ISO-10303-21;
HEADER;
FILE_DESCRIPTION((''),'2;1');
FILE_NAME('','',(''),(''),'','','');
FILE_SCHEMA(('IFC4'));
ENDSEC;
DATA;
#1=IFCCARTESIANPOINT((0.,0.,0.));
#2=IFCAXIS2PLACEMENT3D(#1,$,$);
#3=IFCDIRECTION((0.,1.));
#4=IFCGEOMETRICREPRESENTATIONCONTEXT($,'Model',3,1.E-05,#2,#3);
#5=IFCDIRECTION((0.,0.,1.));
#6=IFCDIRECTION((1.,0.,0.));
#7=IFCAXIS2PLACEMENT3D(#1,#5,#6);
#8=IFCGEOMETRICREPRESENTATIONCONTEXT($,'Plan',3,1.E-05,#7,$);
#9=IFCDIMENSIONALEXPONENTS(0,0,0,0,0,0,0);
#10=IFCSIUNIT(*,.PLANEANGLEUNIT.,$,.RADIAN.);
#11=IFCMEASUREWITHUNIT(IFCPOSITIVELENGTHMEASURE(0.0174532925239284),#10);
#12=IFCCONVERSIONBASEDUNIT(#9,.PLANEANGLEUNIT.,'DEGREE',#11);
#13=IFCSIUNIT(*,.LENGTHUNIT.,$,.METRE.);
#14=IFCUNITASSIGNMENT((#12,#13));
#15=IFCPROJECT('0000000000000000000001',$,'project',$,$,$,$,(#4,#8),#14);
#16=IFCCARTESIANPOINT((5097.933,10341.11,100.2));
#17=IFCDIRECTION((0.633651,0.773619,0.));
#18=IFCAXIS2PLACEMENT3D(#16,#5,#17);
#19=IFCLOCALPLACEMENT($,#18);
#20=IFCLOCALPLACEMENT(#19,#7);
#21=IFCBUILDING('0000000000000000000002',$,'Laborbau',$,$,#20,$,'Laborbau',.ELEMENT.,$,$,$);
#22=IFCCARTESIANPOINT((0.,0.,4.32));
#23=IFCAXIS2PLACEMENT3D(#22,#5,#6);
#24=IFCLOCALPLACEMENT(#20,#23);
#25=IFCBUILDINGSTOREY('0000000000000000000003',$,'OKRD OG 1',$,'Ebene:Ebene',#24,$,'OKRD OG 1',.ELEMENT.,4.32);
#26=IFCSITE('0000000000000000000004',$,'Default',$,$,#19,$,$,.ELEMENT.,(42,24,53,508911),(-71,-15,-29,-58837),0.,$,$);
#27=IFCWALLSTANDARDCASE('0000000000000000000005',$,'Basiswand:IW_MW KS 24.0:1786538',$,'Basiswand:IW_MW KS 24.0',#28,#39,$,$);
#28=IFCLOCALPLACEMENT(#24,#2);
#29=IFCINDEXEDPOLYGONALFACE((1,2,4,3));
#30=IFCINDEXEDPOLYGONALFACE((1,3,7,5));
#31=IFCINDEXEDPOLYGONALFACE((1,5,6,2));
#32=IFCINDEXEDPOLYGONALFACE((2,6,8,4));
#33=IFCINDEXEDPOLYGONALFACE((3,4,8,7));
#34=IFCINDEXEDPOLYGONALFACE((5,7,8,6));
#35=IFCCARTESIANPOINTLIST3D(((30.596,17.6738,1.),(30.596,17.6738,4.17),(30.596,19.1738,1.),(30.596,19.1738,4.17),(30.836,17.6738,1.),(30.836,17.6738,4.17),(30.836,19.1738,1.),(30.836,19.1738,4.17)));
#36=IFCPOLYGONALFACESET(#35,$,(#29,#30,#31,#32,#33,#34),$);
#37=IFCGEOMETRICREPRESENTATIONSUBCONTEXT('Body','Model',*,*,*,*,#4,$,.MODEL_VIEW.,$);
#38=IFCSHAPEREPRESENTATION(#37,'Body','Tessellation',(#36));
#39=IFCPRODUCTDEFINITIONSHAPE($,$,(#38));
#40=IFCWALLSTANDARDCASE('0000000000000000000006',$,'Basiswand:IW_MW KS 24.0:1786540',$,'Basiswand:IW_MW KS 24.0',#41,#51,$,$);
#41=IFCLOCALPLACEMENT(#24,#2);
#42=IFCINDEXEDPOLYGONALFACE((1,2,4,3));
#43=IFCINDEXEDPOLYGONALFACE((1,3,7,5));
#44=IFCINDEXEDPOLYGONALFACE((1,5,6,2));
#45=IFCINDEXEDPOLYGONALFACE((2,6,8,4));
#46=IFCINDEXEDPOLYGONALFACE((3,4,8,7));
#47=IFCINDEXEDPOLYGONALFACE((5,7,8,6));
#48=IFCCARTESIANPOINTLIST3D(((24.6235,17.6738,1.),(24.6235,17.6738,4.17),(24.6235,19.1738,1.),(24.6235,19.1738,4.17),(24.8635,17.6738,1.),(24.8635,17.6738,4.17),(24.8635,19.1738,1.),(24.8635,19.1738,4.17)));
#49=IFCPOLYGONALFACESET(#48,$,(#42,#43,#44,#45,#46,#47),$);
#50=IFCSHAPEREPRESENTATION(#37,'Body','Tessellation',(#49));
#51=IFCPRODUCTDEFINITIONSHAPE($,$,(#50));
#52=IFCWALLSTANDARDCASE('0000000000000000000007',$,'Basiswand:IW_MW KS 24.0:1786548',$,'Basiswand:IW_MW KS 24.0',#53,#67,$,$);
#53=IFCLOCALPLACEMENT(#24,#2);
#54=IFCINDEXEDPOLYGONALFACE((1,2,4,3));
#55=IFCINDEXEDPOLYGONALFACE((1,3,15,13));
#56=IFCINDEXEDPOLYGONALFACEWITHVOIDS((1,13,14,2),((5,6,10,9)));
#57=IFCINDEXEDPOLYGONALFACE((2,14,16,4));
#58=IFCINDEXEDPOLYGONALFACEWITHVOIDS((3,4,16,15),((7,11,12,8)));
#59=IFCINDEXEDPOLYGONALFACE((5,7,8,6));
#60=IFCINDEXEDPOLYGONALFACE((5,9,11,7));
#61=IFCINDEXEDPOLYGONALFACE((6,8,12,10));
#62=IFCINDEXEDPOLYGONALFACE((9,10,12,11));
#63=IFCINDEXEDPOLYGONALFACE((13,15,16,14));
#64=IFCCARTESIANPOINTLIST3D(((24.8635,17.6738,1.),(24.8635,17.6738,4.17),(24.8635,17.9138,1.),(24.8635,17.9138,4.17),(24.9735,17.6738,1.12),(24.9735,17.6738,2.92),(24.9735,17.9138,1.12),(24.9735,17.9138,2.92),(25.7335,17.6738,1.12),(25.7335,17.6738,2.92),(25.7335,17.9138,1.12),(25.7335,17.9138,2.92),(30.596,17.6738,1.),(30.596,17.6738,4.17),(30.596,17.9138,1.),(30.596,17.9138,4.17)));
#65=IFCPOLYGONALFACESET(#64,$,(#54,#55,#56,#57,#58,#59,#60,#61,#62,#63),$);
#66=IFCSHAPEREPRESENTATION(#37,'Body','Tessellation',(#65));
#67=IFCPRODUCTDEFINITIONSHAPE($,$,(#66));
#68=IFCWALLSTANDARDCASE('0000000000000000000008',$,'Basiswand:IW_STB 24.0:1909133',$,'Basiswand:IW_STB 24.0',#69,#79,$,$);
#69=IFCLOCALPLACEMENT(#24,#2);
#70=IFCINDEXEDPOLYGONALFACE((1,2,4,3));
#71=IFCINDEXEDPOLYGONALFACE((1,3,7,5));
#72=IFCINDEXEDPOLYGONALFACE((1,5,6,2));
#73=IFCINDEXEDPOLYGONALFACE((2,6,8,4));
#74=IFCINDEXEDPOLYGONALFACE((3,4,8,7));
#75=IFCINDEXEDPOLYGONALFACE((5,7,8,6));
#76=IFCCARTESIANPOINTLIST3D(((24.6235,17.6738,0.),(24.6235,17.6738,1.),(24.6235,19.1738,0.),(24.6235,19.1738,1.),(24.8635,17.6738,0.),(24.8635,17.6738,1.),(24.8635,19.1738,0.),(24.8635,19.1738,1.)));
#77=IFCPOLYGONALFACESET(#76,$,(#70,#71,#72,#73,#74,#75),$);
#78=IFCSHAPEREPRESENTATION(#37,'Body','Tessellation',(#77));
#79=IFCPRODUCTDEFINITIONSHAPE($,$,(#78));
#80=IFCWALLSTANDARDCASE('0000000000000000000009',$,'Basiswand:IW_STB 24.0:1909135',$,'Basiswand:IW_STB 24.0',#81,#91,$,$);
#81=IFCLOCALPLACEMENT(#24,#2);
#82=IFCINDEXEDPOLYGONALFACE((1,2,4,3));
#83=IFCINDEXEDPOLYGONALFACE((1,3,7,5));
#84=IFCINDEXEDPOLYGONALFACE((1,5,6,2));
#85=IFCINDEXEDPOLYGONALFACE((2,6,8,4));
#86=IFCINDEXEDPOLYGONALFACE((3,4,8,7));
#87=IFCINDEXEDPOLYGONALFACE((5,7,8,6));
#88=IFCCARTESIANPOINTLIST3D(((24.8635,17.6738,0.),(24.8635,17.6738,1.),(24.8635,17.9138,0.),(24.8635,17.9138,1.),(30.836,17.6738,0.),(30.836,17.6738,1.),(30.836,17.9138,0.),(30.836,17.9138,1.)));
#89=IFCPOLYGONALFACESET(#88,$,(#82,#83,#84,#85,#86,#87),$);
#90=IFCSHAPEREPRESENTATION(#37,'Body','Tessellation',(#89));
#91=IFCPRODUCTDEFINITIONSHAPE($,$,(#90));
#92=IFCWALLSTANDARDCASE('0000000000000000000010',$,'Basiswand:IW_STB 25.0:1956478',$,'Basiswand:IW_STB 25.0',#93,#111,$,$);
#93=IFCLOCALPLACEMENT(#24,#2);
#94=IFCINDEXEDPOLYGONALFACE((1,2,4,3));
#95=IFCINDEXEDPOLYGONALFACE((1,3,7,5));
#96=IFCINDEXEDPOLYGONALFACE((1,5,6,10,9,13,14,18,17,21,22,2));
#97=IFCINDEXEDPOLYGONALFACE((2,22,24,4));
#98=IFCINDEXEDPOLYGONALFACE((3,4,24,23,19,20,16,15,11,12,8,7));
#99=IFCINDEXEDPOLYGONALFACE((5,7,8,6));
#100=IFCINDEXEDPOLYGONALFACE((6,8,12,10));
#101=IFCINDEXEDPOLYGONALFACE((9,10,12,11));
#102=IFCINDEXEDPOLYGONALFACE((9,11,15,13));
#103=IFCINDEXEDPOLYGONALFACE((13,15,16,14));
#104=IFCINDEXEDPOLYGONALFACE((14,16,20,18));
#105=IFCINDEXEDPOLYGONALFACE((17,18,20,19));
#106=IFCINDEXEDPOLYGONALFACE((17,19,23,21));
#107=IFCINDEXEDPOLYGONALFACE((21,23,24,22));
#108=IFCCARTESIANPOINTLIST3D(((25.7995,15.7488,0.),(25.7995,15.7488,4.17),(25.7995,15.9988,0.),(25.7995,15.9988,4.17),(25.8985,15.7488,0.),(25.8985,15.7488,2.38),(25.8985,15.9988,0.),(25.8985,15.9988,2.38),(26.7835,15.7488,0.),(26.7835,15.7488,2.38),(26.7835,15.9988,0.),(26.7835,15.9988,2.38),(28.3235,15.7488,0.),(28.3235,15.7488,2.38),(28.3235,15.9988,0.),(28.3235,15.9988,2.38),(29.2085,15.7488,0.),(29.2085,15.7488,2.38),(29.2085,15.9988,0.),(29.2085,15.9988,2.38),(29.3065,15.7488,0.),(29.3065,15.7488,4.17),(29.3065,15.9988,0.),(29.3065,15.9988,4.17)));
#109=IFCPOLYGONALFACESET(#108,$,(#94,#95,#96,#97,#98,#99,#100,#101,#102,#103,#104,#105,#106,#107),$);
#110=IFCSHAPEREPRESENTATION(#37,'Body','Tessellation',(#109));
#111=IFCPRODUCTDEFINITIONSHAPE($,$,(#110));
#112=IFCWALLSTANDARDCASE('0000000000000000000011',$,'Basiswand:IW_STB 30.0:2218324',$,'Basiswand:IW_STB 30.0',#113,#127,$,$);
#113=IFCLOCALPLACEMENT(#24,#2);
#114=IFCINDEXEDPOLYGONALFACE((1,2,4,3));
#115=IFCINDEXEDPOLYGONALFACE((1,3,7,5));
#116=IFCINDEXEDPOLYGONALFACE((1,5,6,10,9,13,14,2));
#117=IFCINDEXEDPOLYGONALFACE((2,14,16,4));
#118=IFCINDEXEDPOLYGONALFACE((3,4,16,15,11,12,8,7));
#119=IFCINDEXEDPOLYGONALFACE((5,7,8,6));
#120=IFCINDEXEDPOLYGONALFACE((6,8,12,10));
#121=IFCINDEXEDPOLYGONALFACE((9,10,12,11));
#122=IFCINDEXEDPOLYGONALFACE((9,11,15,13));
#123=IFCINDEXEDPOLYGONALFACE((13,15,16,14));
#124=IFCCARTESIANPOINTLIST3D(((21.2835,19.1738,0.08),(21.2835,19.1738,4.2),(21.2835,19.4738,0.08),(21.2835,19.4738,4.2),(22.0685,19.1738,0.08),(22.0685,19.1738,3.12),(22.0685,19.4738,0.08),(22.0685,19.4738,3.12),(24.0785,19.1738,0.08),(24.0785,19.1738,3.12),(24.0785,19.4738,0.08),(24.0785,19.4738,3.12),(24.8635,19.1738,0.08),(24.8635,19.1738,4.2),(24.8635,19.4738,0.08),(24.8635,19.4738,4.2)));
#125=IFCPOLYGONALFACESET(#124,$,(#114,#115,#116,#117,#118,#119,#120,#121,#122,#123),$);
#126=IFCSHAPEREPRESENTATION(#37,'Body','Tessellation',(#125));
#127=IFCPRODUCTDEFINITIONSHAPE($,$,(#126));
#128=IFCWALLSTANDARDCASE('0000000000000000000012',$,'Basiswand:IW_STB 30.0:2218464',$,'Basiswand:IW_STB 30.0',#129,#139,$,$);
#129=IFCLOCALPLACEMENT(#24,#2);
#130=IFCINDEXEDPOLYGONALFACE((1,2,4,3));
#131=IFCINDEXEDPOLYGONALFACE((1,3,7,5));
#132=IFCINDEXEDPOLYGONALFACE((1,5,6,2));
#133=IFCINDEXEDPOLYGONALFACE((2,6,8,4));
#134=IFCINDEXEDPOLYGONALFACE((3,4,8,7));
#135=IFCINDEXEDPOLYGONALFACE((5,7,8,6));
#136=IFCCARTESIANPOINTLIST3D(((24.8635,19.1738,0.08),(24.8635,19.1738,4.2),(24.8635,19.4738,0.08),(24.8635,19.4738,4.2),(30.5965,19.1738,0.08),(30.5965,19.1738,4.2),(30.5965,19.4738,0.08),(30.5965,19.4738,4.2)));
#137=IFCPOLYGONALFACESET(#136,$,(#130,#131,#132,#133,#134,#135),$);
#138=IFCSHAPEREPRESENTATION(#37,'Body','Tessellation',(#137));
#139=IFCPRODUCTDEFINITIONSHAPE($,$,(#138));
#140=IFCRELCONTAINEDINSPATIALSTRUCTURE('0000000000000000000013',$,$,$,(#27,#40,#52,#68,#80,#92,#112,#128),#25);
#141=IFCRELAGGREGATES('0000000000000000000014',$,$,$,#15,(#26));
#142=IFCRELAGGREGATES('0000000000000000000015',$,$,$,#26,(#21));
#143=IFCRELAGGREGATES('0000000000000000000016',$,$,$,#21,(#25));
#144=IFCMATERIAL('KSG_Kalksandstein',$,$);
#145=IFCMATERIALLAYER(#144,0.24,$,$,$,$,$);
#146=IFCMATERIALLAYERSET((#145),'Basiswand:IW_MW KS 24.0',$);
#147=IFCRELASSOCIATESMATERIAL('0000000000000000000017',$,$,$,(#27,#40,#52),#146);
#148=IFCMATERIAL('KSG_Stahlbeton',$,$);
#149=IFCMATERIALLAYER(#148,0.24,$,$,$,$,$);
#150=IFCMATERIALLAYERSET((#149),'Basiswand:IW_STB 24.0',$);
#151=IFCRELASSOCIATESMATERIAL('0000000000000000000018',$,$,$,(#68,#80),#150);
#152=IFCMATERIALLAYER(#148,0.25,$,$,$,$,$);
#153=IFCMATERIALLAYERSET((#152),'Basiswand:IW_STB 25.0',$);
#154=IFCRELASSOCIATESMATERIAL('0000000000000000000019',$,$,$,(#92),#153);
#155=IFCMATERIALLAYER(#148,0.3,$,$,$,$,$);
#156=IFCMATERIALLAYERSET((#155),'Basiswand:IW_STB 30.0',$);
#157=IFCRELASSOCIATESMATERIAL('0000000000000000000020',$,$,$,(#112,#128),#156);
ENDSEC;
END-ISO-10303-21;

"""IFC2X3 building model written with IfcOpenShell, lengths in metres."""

from ifc_helpers import new_model, entity, si_unit, converted_unit, direction, frame, frame_2d, origin, origin_with_axes, place, context, subcontext, project, spatial, rectangle, extrude, material, layer, layer_set, layer_usage, element, save


model = new_model("IFC2X3")

# Units and contexts
model_context = context("Model", 3, precision=1e-05, world=origin(), true_north=direction((0.0, 1.0)))
plan_context = context("Plan", 3, precision=1e-05, world=origin_with_axes())
body_context = subcontext(model_context, "Body", "Model", "MODEL_VIEW")
ifc_project = project(units=[converted_unit("PLANEANGLEUNIT", "DEGREE", entity("IfcPositiveLengthMeasure", 0.0174532925239284), si_unit("PLANEANGLEUNIT", "RADIAN"), dimensions=[0, 0, 0, 0, 0, 0, 0]), si_unit("LENGTHUNIT", "METRE")], contexts=[model_context, plan_context])

# Site, building, storey
site_placement = place(None, frame((5097.933, 10341.11, 100.2), z_axis=(0.0, 0.0, 1.0), x_axis=(0.633651, 0.773619, 0.0)))
site = spatial("IfcSite", under=ifc_project, at=site_placement, Name="Default", CompositionType="ELEMENT", RefLatitude=(42, 24, 53, 508911), RefLongitude=(-71, -15, -29, -58837), RefElevation=0.0)
building_placement = place(site_placement, origin_with_axes())
building = spatial("IfcBuilding", under=site, at=building_placement, Name="Laborbau", LongName="Laborbau", CompositionType="ELEMENT")
storey_placement = place(building_placement, frame((0.0, 0.0, 4.32), z_axis=(0.0, 0.0, 1.0), x_axis=(1.0, 0.0, 0.0)))
storey = spatial("IfcBuildingStorey", under=building, at=storey_placement, Name="OKRD OG 1", ObjectType="Ebene:Ebene", LongName="OKRD OG 1", CompositionType="ELEMENT", Elevation=4.32)

# Walls
ifc_material_1 = material(Name="KSG_Kalksandstein")
ifc_layer_1 = layer(ifc_material_1, 0.24)
ifc_layer_set_1 = layer_set([ifc_layer_1], Name="Basiswand:IW_MW KS 24.0")
ifc_layer_usage_1 = layer_usage(ifc_layer_set_1, "AXIS2", "NEGATIVE", 0.12)
wall_1_placement = place(storey_placement, frame((30.716, 19.1738, 1.0), z_axis=(0.0, 0.0, 1.0), x_axis=(0.0, -1.0, 0.0)))
element("IfcWallStandardCase", 1, at=wall_1_placement, inside=storey, material=ifc_layer_usage_1, Name="Basiswand:IW_MW KS 24.0:1786538", ObjectType="Basiswand:IW_MW KS 24.0", context=body_context, shape_type="SweptSolid", body=[
    extrude(rectangle(XDim=1.5, YDim=0.24, at=frame_2d((0.75, 0.0), x_axis=(-1.0, 0.0))), origin(), (0.0, 0.0, 1.0), 3.17),
])
ifc_layer_usage_2 = layer_usage(ifc_layer_set_1, "AXIS2", "NEGATIVE", 0.12)
wall_2_placement = place(storey_placement, frame((24.7435, 17.6738, 1.0), z_axis=(0.0, 0.0, 1.0), x_axis=(0.0, 1.0, 0.0)))
element("IfcWallStandardCase", 2, at=wall_2_placement, inside=storey, material=ifc_layer_usage_2, Name="Basiswand:IW_MW KS 24.0:1786540", ObjectType="Basiswand:IW_MW KS 24.0", context=body_context, shape_type="SweptSolid", body=[
    extrude(rectangle(XDim=1.5, YDim=0.24, at=frame_2d((0.75, 0.0), x_axis=(-1.0, 0.0))), origin(), (0.0, 0.0, 1.0), 3.17),
])

# Wall, openings
ifc_layer_usage_3 = layer_usage(ifc_layer_set_1, "AXIS2", "NEGATIVE", 0.12)
wall_3_placement = place(storey_placement, frame((24.8635, 17.7938, 1.0), z_axis=(0.0, 0.0, 1.0), x_axis=(1.0, 0.0, 0.0)))
wall_3 = element("IfcWallStandardCase", 3, at=wall_3_placement, inside=storey, material=ifc_layer_usage_3, Name="Basiswand:IW_MW KS 24.0:1786548", ObjectType="Basiswand:IW_MW KS 24.0", context=body_context, shape_type="SweptSolid", body=[
    extrude(rectangle(XDim=5.7325, YDim=0.24, at=frame_2d((2.8662, 0.0), x_axis=(-1.0, 0.0))), origin(), (0.0, 0.0, 1.0), 3.17),
])
opening_1_placement = place(wall_3_placement, frame((-24.8635, -17.7938, -1.0), z_axis=(0.0, 0.0, 1.0), x_axis=(1.0, 0.0, 0.0)))
element("IfcOpeningElement", 4, at=opening_1_placement, cuts=wall_3, ObjectType="Opening", context=body_context, shape_type="SweptSolid", body=[
    extrude(rectangle(XDim=1.8, YDim=0.76, at=frame_2d((0.0, 0.0), x_axis=(0.0, 1.0))), frame((25.3535, 16.3898, 2.02), z_axis=(0.0, 1.0, 0.0), x_axis=(-1.0, 0.0, 0.0)), (0.0, 0.0, 1.0), 3.048),
])
opening_2_placement = place(wall_3_placement, frame((0.87, 0.12, 0.12), z_axis=(0.0, 0.0, 1.0), x_axis=(1.0, 0.0, 0.0)))
element("IfcOpeningElement", 5, at=opening_2_placement, cuts=wall_3, ObjectType="Opening", context=body_context, shape_type="SweptSolid", body=[
    extrude(rectangle(XDim=1.8, YDim=0.76, at=frame_2d((0.9, 0.38), x_axis=(1.0, 0.0))), frame((0.0, 0.0, 0.0), z_axis=(0.0, -1.0, 0.0), x_axis=(0.0, 0.0, 1.0)), (0.0, 0.0, 1.0), 0.24),
])

# Walls
ifc_material_2 = material(Name="KSG_Stahlbeton")
ifc_layer_2 = layer(ifc_material_2, 0.24)
ifc_layer_set_2 = layer_set([ifc_layer_2], Name="Basiswand:IW_STB 24.0")
ifc_layer_usage_4 = layer_usage(ifc_layer_set_2, "AXIS2", "NEGATIVE", 0.12)
wall_4_placement = place(storey_placement, frame((24.7435, 19.1738, 0.0), z_axis=(0.0, 0.0, 1.0), x_axis=(0.0, -1.0, 0.0)))
element("IfcWallStandardCase", 6, at=wall_4_placement, inside=storey, material=ifc_layer_usage_4, Name="Basiswand:IW_STB 24.0:1909133", ObjectType="Basiswand:IW_STB 24.0", context=body_context, shape_type="SweptSolid", body=[
    extrude(rectangle(XDim=1.5, YDim=0.24, at=frame_2d((0.75, 0.0), x_axis=(-1.0, 0.0))), origin(), (0.0, 0.0, 1.0), 1.0),
])
ifc_layer_usage_5 = layer_usage(ifc_layer_set_2, "AXIS2", "NEGATIVE", 0.12)
wall_5_placement = place(storey_placement, frame((24.8635, 17.7938, 0.0), z_axis=(0.0, 0.0, 1.0), x_axis=(1.0, 0.0, 0.0)))
element("IfcWallStandardCase", 7, at=wall_5_placement, inside=storey, material=ifc_layer_usage_5, Name="Basiswand:IW_STB 24.0:1909135", ObjectType="Basiswand:IW_STB 24.0", context=body_context, shape_type="SweptSolid", body=[
    extrude(rectangle(XDim=5.9725, YDim=0.24, at=frame_2d((2.9863, 0.0), x_axis=(-1.0, 0.0))), origin(), (0.0, 0.0, 1.0), 1.0),
])

# Walls, openings
ifc_layer_3 = layer(ifc_material_2, 0.25)
ifc_layer_set_3 = layer_set([ifc_layer_3], Name="Basiswand:IW_STB 25.0")
ifc_layer_usage_6 = layer_usage(ifc_layer_set_3, "AXIS2", "NEGATIVE", 0.125)
wall_6_placement = place(storey_placement, frame((25.7995, 15.8738, 0.0), z_axis=(0.0, 0.0, 1.0), x_axis=(1.0, 0.0, 0.0)))
wall_6 = element("IfcWallStandardCase", 8, at=wall_6_placement, inside=storey, material=ifc_layer_usage_6, Name="Basiswand:IW_STB 25.0:1956478", ObjectType="Basiswand:IW_STB 25.0", context=body_context, shape_type="SweptSolid", body=[
    extrude(rectangle(XDim=3.507, YDim=0.25, at=frame_2d((1.7535, 0.0), x_axis=(-1.0, 0.0))), origin(), (0.0, 0.0, 1.0), 4.17),
])
opening_3_placement = place(wall_6_placement, frame((0.099, -0.125, 0.0), z_axis=(0.0, 0.0, 1.0), x_axis=(1.0, 0.0, 0.0)))
element("IfcOpeningElement", 9, at=opening_3_placement, cuts=wall_6, ObjectType="Opening", context=body_context, shape_type="SweptSolid", body=[
    extrude(rectangle(XDim=2.38, YDim=0.885, at=frame_2d((1.19, 0.4425), x_axis=(1.0, 0.0))), frame((0.0, 0.0, 0.0), z_axis=(0.0, 1.0, 0.0), x_axis=(0.0, 0.0, 1.0)), (0.0, 0.0, 1.0), 0.25),
])
opening_4_placement = place(wall_6_placement, frame((-25.7995, -15.8738, 0.0), z_axis=(0.0, 0.0, 1.0), x_axis=(1.0, 0.0, 0.0)))
element("IfcOpeningElement", 10, at=opening_4_placement, cuts=wall_6, ObjectType="Opening", context=body_context, shape_type="SweptSolid", body=[
    extrude(rectangle(XDim=2.38, YDim=0.885, at=frame_2d((0.0, 0.0), x_axis=(0.0, 1.0))), frame((26.341, 14.2248, 1.19), z_axis=(0.0, 1.0, 0.0), x_axis=(-1.0, 0.0, 0.0)), (0.0, 0.0, 1.0), 3.048),
])
opening_5_placement = place(wall_6_placement, frame((2.524, -0.125, 0.0), z_axis=(0.0, 0.0, 1.0), x_axis=(1.0, 0.0, 0.0)))
element("IfcOpeningElement", 11, at=opening_5_placement, cuts=wall_6, ObjectType="Opening", context=body_context, shape_type="SweptSolid", body=[
    extrude(rectangle(XDim=2.38, YDim=0.885, at=frame_2d((1.19, 0.4425), x_axis=(1.0, 0.0))), frame((0.0, 0.0, 0.0), z_axis=(0.0, 1.0, 0.0), x_axis=(0.0, 0.0, 1.0)), (0.0, 0.0, 1.0), 0.25),
])
opening_6_placement = place(wall_6_placement, frame((-25.7995, -15.8738, 0.0), z_axis=(0.0, 0.0, 1.0), x_axis=(1.0, 0.0, 0.0)))
element("IfcOpeningElement", 12, at=opening_6_placement, cuts=wall_6, ObjectType="Opening", context=body_context, shape_type="SweptSolid", body=[
    extrude(rectangle(XDim=2.38, YDim=0.885, at=frame_2d((0.0, 0.0), x_axis=(1.0, 0.0))), frame((28.766, 14.2248, 1.19), z_axis=(0.0, 1.0, 0.0), x_axis=(0.0, 0.0, 1.0)), (0.0, 0.0, 1.0), 3.048),
])
ifc_layer_4 = layer(ifc_material_2, 0.3)
ifc_layer_set_4 = layer_set([ifc_layer_4], Name="Basiswand:IW_STB 30.0")
ifc_layer_usage_7 = layer_usage(ifc_layer_set_4, "AXIS2", "POSITIVE", -0.15)
wall_7_placement = place(storey_placement, frame((24.8635, 19.3238, 0.08), z_axis=(0.0, 0.0, 1.0), x_axis=(-1.0, 0.0, 0.0)))
wall_7 = element("IfcWallStandardCase", 13, at=wall_7_placement, inside=storey, material=ifc_layer_usage_7, Name="Basiswand:IW_STB 30.0:2218324", ObjectType="Basiswand:IW_STB 30.0", context=body_context, shape_type="SweptSolid", body=[
    extrude(rectangle(XDim=3.58, YDim=0.3, at=frame_2d((1.79, 0.0), x_axis=(-1.0, 0.0))), origin(), (0.0, 0.0, 1.0), 4.12),
])
opening_7_placement = place(wall_7_placement, frame((0.785, -0.15, 0.0), z_axis=(0.0, 0.0, 1.0), x_axis=(1.0, 0.0, 0.0)))
element("IfcOpeningElement", 14, at=opening_7_placement, cuts=wall_7, ObjectType="Opening", context=body_context, shape_type="SweptSolid", body=[
    extrude(rectangle(XDim=3.04, YDim=2.01, at=frame_2d((1.52, 1.005), x_axis=(1.0, 0.0))), frame((0.0, 0.0, 0.0), z_axis=(0.0, 1.0, 0.0), x_axis=(0.0, 0.0, 1.0)), (0.0, 0.0, 1.0), 0.3),
])
opening_8_placement = place(wall_7_placement, frame((24.8635, 19.3238, -0.08), z_axis=(0.0, 0.0, 1.0), x_axis=(-1.0, 0.0, 0.0)))
element("IfcOpeningElement", 15, at=opening_8_placement, cuts=wall_7, ObjectType="Opening", context=body_context, shape_type="SweptSolid", body=[
    extrude(rectangle(XDim=3.04, YDim=2.01, at=frame_2d((0.0, 0.0), x_axis=(1.0, 0.0))), frame((23.0735, 20.6978, 1.6), z_axis=(0.0, -1.0, 0.0), x_axis=(0.0, 0.0, 1.0)), (0.0, 0.0, 1.0), 3.048),
])

# Wall
ifc_layer_usage_8 = layer_usage(ifc_layer_set_4, "AXIS2", "POSITIVE", -0.15)
wall_8_placement = place(storey_placement, frame((30.5965, 19.3238, 0.08), z_axis=(0.0, 0.0, 1.0), x_axis=(-1.0, 0.0, 0.0)))
element("IfcWallStandardCase", 16, at=wall_8_placement, inside=storey, material=ifc_layer_usage_8, Name="Basiswand:IW_STB 30.0:2218464", ObjectType="Basiswand:IW_STB 30.0", context=body_context, shape_type="SweptSolid", body=[
    extrude(rectangle(XDim=5.733, YDim=0.3, at=frame_2d((2.8665, 0.0), x_axis=(-1.0, 0.0))), origin(), (0.0, 0.0, 1.0), 4.12),
])

save(model, "model.ifc")
